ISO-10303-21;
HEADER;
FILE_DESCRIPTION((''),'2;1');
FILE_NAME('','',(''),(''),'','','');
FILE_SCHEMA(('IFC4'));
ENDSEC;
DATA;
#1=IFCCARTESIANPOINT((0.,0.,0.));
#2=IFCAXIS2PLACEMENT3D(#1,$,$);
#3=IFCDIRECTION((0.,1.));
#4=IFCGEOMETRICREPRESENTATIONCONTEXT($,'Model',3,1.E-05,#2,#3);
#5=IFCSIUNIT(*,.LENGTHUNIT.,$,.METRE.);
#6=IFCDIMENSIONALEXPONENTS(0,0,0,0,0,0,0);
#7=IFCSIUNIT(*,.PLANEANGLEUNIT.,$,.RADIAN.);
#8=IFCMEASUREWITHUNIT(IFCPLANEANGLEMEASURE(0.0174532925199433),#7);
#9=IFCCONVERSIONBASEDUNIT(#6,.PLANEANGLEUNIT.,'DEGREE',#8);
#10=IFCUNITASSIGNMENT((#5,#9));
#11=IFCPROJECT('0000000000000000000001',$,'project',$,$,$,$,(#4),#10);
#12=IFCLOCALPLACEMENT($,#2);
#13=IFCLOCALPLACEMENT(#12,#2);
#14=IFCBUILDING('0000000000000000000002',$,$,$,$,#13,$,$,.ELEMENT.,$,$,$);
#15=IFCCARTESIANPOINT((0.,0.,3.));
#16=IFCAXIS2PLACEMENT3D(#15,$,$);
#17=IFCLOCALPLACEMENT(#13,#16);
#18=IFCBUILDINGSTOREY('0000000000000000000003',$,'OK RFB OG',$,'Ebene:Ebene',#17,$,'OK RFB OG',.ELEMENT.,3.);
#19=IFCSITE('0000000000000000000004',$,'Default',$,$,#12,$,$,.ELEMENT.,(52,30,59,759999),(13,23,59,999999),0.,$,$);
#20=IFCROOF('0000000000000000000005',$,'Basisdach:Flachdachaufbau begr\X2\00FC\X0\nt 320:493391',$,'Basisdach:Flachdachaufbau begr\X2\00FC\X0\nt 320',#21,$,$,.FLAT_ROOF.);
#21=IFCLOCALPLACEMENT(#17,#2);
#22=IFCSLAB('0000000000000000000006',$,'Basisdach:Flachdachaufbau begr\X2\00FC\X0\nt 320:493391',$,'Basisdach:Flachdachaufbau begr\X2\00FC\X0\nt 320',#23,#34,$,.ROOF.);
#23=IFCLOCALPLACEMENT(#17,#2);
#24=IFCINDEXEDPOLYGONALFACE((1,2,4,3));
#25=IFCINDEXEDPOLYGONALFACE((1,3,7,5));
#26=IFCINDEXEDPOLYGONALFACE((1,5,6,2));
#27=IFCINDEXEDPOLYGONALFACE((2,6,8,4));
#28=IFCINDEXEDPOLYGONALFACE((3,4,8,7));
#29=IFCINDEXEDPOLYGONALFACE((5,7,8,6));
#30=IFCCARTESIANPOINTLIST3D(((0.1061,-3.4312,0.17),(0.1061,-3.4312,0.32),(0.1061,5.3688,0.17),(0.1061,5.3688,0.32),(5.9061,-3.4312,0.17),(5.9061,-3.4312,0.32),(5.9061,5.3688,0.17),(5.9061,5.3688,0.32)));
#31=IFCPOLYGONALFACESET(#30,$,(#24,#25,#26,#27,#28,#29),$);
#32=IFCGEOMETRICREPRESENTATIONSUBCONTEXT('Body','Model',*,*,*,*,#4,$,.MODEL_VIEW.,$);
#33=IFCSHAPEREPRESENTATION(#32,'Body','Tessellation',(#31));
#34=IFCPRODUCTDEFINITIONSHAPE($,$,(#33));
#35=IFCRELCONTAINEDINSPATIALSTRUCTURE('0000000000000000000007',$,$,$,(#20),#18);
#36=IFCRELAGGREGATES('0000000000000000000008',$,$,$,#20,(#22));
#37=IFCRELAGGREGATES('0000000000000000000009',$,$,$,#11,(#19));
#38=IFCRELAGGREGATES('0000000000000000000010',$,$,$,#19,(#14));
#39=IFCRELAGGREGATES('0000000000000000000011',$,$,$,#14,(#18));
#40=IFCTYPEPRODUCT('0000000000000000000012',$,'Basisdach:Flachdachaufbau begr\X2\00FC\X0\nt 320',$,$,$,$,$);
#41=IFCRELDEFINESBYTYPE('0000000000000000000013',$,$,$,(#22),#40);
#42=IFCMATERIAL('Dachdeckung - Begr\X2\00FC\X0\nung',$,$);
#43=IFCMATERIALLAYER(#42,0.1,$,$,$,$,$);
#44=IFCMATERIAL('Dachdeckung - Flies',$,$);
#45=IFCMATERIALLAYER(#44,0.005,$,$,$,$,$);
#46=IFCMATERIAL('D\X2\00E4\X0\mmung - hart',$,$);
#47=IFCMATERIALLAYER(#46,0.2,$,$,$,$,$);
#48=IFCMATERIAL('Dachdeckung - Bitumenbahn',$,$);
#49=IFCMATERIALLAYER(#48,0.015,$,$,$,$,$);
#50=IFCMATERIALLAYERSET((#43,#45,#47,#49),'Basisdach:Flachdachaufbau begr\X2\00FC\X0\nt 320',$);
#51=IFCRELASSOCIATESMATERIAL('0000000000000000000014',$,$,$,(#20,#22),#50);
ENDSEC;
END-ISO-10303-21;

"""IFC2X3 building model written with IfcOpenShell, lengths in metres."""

from ifc_helpers import new_model, entity, si_unit, converted_unit, direction, frame, frame_2d, origin, place, context, subcontext, project, spatial, rectangle, extrude, material, layer, layer_set, type_object, element, aggregate, save


model = new_model("IFC2X3")

# Units and contexts
model_context = context("Model", 3, precision=1e-05, world=origin(), true_north=direction((0.0, 1.0)))
body_context = subcontext(model_context, "Body", "Model", "MODEL_VIEW")
ifc_project = project(units=[si_unit("LENGTHUNIT", "METRE"), converted_unit("PLANEANGLEUNIT", "DEGREE", entity("IfcPlaneAngleMeasure", 0.0174532925199433), si_unit("PLANEANGLEUNIT", "RADIAN"), dimensions=[0, 0, 0, 0, 0, 0, 0])], contexts=[model_context])

# Site, building, storey
site_placement = place(None, origin())
site = spatial("IfcSite", under=ifc_project, at=site_placement, Name="Default", CompositionType="ELEMENT", RefLatitude=(52, 30, 59, 759999), RefLongitude=(13, 23, 59, 999999), RefElevation=0.0)
building_placement = place(site_placement, origin())
building = spatial("IfcBuilding", under=site, at=building_placement, CompositionType="ELEMENT")
storey_placement = place(building_placement, frame((0.0, 0.0, 3.0)))
storey = spatial("IfcBuildingStorey", under=building, at=storey_placement, Name="OK RFB OG", ObjectType="Ebene:Ebene", LongName="OK RFB OG", CompositionType="ELEMENT", Elevation=3.0)

# Roof, slab
ifc_material_1 = material(Name="Dachdeckung - Begrünung")
ifc_layer_1 = layer(ifc_material_1, 0.1)
ifc_material_2 = material(Name="Dachdeckung - Flies")
ifc_layer_2 = layer(ifc_material_2, 0.005)
ifc_material_3 = material(Name="Dämmung - hart")
ifc_layer_3 = layer(ifc_material_3, 0.2)
ifc_material_4 = material(Name="Dachdeckung - Bitumenbahn")
ifc_layer_4 = layer(ifc_material_4, 0.015)
ifc_layer_set = layer_set([ifc_layer_1, ifc_layer_2, ifc_layer_3, ifc_layer_4], Name="Basisdach:Flachdachaufbau begrünt 320")
roof_placement = place(storey_placement, frame((0.1061, -3.4312, 0.17)))
roof = element("IfcRoof", 1, at=roof_placement, inside=storey, material=ifc_layer_set, Name="Basisdach:Flachdachaufbau begrünt 320:493391", ObjectType="Basisdach:Flachdachaufbau begrünt 320", ShapeType="FLAT_ROOF")
type_product = type_object("IfcTypeProduct", Name="Basisdach:Flachdachaufbau begrünt 320")
slab_placement = place(roof_placement, origin())
slab = element("IfcSlab", 2, at=slab_placement, type_object=type_product, material=ifc_layer_set, Name="Basisdach:Flachdachaufbau begrünt 320:493391", ObjectType="Basisdach:Flachdachaufbau begrünt 320", PredefinedType="ROOF", context=body_context, shape_type="SweptSolid", body=[
    extrude(rectangle(XDim=8.8, YDim=5.8, at=frame_2d((0.0, 0.0), x_axis=(0.0, 1.0))), frame((2.9, 4.4, 0.0)), (0.0, 0.0, 1.0), 0.15),
])
aggregate(roof, [slab])

save(model, "model.ifc")
